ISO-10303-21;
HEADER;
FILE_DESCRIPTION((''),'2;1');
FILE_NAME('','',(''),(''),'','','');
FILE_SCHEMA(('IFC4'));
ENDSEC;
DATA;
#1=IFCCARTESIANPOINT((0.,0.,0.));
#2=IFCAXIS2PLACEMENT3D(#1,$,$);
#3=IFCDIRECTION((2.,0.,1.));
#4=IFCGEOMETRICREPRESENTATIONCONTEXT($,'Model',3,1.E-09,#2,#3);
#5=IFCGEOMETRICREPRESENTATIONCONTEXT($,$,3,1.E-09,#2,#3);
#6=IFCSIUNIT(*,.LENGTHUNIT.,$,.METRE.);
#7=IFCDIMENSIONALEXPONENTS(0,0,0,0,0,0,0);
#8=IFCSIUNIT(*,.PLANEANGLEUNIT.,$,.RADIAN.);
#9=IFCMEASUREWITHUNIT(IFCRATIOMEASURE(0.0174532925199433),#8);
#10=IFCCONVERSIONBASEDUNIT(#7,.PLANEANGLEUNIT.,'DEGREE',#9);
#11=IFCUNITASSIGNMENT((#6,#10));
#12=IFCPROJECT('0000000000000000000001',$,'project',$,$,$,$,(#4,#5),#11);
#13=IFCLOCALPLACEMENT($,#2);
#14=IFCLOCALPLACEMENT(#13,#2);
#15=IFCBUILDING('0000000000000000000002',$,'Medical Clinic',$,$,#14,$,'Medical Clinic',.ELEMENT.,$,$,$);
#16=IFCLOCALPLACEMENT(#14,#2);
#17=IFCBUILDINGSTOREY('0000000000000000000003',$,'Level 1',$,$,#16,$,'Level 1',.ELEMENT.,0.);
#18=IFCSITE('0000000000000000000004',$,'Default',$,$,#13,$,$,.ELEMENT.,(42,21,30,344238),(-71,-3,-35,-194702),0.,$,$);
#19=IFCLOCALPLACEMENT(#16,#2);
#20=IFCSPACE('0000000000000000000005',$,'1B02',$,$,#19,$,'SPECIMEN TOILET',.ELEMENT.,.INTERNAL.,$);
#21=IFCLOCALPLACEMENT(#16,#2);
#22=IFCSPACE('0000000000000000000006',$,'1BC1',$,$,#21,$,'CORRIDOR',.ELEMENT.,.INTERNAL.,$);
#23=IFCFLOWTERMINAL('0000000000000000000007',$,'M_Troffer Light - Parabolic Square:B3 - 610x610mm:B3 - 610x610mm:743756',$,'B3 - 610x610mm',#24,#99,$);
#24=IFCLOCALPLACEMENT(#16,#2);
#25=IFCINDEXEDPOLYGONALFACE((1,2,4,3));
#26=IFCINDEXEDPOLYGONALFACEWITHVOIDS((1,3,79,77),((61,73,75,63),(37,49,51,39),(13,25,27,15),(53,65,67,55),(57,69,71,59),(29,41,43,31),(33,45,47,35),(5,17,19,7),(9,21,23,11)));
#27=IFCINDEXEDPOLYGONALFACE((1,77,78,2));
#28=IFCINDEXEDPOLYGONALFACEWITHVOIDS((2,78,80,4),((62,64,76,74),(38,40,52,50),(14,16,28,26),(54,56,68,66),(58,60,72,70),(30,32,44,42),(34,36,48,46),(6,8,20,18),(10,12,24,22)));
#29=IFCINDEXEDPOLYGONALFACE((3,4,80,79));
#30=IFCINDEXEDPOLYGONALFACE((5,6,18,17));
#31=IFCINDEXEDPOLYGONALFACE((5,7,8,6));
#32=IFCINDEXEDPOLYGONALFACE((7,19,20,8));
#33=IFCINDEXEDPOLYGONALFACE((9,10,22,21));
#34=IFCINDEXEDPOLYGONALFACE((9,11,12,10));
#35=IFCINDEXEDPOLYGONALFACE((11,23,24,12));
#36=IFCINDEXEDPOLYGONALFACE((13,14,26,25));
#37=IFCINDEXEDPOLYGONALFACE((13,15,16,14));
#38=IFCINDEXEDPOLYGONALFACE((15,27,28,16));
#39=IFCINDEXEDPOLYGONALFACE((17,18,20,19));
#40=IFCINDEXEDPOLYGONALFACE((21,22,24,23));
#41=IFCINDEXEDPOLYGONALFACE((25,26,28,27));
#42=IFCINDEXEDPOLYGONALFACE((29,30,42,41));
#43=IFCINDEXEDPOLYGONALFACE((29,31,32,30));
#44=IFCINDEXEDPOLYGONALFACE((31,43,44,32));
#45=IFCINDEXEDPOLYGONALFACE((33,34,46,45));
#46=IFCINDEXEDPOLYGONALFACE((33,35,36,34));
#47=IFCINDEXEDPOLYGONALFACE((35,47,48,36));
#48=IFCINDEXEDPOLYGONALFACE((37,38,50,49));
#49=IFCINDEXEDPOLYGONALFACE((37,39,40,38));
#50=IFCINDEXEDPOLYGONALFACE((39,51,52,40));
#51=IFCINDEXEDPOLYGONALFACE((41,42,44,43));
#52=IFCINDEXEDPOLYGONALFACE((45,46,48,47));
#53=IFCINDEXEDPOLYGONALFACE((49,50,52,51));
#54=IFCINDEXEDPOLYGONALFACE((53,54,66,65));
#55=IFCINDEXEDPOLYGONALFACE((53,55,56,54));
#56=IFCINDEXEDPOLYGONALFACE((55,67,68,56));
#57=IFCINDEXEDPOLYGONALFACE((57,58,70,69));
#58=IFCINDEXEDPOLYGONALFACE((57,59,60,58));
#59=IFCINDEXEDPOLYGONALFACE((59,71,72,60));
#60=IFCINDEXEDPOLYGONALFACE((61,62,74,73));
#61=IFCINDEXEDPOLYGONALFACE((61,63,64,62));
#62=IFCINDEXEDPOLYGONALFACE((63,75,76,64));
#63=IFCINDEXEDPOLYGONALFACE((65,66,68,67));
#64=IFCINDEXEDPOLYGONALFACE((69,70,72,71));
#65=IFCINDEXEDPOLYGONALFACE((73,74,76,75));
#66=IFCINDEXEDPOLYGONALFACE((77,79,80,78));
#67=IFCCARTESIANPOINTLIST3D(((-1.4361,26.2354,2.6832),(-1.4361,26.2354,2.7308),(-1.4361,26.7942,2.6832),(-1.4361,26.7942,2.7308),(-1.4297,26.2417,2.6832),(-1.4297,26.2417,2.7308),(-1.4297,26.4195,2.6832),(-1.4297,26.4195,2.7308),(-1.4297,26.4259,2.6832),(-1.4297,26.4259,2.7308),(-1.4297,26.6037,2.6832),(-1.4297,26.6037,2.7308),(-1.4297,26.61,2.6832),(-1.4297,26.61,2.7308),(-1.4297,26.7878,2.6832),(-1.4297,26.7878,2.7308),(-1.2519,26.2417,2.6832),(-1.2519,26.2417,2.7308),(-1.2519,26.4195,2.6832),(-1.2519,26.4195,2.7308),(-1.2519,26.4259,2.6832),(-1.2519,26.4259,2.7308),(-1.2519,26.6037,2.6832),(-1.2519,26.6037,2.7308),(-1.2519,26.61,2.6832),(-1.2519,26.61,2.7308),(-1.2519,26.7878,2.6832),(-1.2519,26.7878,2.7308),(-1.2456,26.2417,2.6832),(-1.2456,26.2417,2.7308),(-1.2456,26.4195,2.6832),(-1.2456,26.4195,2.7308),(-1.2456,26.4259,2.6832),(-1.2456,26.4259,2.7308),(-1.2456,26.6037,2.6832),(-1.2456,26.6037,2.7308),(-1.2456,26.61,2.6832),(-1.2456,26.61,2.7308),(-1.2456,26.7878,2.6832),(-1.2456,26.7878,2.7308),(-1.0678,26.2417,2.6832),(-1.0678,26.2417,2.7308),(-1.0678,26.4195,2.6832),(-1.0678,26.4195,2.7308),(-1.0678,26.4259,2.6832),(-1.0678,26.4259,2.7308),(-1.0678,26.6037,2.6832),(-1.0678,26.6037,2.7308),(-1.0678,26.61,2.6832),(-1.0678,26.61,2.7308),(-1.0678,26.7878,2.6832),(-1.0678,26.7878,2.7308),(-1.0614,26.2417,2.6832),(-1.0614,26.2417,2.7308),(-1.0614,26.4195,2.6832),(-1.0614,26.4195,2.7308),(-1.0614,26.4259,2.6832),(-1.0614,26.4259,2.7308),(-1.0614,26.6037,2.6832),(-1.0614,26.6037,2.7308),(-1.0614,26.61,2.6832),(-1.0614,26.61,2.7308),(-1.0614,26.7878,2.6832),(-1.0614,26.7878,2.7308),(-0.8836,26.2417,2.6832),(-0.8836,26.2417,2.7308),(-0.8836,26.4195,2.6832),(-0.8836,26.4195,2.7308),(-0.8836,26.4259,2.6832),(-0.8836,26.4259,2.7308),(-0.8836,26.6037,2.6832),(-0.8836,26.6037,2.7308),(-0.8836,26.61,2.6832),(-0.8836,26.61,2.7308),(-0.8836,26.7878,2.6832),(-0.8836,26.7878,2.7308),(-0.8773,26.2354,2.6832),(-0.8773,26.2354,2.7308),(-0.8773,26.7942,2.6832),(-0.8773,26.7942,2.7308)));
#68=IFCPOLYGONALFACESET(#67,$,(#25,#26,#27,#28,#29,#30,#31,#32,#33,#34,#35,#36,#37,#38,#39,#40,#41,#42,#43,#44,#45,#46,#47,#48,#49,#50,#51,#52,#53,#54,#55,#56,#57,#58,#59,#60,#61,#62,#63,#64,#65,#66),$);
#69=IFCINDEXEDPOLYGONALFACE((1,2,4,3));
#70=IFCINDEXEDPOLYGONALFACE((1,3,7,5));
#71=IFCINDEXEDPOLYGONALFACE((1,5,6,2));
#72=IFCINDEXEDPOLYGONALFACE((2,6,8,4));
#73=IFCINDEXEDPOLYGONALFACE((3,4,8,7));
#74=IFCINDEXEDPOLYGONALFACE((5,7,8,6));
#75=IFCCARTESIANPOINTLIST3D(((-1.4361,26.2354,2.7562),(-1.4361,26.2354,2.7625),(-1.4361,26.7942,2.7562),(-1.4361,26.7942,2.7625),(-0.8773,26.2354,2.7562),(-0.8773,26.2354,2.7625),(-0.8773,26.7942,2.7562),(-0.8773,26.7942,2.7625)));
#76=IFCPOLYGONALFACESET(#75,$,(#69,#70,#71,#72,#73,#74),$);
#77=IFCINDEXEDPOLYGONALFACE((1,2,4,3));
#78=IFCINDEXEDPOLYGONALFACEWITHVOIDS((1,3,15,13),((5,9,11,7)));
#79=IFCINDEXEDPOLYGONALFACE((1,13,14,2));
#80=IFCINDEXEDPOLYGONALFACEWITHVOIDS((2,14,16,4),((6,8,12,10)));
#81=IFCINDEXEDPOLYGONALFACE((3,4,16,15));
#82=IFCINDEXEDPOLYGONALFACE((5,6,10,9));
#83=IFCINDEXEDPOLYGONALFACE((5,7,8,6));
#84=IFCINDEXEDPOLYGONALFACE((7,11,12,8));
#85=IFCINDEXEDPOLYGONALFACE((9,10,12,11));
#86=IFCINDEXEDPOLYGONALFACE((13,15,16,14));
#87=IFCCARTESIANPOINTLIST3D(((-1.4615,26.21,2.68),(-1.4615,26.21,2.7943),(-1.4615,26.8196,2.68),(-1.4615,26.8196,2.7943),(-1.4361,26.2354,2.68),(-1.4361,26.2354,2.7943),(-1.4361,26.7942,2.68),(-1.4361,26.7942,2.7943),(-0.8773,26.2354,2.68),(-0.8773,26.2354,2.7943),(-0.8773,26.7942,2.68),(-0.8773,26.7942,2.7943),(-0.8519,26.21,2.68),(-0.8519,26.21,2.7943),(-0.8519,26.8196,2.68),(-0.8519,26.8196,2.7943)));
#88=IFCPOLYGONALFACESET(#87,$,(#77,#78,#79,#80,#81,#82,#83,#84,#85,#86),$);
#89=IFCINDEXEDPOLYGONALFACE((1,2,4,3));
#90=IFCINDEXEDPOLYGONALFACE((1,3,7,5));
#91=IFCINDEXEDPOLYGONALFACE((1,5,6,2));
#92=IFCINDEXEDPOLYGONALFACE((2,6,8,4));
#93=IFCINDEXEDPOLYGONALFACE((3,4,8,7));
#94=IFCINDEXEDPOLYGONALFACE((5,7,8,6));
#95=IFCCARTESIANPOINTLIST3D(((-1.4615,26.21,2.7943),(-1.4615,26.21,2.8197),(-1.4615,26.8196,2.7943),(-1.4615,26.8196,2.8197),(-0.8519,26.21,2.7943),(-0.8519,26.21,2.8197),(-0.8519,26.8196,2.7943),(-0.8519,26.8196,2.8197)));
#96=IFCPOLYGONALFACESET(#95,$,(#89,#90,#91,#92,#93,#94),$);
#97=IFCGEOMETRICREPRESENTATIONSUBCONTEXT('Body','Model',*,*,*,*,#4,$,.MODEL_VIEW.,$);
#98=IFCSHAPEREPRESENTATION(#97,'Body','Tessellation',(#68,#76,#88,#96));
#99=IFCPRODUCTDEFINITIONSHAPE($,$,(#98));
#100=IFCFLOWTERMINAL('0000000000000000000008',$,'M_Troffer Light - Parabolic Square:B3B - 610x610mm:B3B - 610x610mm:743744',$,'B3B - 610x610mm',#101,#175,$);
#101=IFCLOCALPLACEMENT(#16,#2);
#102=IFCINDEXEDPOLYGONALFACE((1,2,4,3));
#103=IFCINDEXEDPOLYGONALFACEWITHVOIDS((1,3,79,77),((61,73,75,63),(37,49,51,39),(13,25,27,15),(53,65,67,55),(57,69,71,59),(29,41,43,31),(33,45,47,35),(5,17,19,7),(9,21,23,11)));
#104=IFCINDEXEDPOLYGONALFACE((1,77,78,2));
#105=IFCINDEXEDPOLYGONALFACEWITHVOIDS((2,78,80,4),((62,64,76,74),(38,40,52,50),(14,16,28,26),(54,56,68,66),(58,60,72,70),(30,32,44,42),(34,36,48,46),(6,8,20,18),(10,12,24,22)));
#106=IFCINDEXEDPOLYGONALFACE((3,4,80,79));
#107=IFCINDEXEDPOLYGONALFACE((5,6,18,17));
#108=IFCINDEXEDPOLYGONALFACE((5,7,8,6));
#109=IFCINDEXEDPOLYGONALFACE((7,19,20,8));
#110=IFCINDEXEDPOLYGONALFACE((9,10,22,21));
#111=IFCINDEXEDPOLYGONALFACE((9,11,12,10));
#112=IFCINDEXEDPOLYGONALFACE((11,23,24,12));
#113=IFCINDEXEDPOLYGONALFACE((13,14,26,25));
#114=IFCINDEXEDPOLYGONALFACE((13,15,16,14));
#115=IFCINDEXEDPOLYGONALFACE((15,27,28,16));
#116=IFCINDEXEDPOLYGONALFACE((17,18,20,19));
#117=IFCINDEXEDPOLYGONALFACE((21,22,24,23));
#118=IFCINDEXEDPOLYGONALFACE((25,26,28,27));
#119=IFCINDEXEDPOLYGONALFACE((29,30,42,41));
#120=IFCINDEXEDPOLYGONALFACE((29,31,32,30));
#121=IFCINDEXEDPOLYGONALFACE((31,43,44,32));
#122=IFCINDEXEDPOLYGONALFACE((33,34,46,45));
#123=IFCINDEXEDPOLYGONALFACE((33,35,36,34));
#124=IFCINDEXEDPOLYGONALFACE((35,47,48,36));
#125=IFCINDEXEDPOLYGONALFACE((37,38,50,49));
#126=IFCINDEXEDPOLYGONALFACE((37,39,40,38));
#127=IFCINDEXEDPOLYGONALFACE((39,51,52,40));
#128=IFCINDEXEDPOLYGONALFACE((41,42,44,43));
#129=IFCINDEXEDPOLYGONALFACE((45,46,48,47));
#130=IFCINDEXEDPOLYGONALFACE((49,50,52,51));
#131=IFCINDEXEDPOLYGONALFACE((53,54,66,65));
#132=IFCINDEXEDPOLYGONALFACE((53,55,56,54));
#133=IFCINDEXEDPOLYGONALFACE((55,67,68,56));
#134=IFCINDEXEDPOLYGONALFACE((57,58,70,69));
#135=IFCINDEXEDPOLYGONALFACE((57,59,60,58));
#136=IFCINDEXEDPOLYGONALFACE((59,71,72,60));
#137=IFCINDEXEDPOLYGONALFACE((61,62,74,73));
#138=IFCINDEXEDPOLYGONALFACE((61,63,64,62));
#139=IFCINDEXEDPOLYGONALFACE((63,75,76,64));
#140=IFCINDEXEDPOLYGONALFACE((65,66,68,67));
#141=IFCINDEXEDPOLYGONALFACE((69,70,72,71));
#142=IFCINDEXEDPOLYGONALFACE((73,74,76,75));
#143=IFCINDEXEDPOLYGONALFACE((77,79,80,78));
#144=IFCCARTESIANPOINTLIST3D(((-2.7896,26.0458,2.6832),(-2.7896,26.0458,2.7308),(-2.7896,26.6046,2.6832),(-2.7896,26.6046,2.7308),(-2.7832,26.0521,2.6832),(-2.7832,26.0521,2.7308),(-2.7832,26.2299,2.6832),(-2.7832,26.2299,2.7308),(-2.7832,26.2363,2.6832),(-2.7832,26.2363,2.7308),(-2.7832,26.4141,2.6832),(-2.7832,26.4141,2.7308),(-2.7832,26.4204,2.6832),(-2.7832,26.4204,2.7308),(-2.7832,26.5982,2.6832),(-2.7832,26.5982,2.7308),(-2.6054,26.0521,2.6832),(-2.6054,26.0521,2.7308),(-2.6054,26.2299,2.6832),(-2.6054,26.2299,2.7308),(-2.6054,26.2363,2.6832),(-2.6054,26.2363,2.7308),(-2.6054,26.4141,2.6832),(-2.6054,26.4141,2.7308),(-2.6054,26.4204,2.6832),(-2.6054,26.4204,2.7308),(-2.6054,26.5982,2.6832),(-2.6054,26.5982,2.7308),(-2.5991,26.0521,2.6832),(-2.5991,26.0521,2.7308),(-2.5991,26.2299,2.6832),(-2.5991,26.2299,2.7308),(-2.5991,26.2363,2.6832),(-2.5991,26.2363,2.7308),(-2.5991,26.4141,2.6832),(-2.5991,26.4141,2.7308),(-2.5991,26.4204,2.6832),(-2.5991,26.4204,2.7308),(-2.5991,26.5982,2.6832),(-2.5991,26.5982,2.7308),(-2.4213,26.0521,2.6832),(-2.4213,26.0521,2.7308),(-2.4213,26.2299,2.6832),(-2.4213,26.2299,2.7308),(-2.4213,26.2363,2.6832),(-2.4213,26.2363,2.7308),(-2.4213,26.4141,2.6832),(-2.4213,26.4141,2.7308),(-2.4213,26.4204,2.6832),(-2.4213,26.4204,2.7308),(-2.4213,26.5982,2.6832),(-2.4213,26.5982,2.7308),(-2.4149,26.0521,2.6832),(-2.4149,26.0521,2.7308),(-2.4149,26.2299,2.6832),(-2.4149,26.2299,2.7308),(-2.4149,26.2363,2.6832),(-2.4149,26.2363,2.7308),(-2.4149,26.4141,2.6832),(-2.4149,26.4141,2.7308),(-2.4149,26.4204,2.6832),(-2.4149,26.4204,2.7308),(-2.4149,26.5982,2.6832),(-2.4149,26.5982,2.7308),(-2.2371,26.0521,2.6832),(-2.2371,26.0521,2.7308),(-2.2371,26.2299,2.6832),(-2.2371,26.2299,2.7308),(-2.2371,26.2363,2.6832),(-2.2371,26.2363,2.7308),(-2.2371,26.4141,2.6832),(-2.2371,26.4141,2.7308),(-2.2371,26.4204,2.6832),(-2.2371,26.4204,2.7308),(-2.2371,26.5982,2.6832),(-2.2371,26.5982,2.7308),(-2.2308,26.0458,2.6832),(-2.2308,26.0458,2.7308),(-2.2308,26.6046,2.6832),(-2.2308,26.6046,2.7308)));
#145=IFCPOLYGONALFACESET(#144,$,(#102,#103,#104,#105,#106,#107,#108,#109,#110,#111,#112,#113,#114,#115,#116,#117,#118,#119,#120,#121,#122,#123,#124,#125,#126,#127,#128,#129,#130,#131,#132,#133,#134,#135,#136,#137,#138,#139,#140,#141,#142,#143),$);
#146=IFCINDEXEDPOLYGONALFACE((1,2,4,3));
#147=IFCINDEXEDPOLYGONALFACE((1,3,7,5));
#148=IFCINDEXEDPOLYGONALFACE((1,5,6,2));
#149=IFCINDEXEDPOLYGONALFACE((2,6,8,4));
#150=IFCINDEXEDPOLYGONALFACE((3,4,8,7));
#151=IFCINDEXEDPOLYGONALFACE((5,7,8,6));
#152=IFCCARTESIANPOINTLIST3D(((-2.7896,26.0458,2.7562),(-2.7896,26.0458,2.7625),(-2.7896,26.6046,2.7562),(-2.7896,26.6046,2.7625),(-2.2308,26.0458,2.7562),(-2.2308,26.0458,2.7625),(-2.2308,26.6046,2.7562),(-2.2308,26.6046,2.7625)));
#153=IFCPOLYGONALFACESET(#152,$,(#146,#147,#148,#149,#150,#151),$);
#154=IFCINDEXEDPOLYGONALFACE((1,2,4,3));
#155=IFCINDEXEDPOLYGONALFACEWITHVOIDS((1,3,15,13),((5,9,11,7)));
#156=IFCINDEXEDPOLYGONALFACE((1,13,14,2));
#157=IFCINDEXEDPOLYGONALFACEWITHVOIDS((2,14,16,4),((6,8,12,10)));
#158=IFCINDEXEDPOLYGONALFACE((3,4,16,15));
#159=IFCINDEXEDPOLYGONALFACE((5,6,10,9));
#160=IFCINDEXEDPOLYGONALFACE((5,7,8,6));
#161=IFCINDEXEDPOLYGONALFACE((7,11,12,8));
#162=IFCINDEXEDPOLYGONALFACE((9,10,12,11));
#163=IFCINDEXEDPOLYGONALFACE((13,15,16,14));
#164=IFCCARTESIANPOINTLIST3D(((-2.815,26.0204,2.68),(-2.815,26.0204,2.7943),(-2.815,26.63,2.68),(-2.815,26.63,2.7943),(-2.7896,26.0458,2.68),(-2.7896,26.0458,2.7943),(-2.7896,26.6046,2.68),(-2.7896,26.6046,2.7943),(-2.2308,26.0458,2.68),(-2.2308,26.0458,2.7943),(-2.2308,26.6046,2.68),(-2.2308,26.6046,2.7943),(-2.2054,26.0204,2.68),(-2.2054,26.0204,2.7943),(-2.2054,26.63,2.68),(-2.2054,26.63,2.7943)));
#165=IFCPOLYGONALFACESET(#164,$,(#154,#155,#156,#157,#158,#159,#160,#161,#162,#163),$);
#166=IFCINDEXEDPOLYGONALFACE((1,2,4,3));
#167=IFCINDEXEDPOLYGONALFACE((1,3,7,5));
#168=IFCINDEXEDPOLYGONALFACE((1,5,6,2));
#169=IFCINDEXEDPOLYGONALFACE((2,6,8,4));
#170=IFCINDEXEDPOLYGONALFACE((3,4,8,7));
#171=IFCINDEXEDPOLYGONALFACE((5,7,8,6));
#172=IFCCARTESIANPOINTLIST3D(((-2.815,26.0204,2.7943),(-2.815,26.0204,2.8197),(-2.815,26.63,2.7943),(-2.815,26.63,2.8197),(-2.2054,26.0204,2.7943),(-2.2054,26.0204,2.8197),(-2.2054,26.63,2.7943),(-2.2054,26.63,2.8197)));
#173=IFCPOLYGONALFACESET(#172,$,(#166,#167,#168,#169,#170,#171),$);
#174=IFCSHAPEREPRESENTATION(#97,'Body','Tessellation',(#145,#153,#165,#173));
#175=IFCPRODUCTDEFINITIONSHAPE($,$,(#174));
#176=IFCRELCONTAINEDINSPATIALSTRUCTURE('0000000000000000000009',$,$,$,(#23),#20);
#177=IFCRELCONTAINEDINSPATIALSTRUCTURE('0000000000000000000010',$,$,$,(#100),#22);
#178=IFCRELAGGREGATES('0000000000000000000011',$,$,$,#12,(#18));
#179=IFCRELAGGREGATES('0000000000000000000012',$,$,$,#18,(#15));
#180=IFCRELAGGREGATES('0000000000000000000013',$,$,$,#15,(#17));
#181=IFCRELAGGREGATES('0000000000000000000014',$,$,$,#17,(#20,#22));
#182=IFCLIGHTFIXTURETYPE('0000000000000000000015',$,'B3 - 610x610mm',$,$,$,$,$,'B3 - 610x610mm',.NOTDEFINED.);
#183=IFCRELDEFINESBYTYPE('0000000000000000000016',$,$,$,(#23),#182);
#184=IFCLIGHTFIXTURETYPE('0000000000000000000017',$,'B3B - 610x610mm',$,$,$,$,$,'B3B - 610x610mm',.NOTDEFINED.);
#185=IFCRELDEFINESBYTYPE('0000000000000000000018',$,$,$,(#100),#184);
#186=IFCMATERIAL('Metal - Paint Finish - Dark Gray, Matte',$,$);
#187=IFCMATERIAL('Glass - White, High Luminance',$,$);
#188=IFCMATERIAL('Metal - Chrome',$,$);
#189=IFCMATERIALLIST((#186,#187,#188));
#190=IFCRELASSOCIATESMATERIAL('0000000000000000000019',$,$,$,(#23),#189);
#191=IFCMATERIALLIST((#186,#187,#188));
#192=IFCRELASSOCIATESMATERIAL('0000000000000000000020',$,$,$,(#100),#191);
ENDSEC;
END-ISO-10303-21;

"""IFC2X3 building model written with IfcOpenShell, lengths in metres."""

from ifc_helpers import new_model, entity, si_unit, converted_unit, direction, frame, origin, origin_2d_with_axis, place, context, subcontext, project, spatial, polyline, rectangle, outline, extrude, source, transform, mapped, material, material_list, type_object, type_shapes, element, save


model = new_model("IFC2X3")

# Units and contexts
model_context = context("Model", 3, precision=1e-09, world=origin(), true_north=direction((2.0, 0.0, 1.0)))
context_of_model = context(None, 3, precision=1e-09, world=origin(), true_north=direction((2.0, 0.0, 1.0)))
body_context = subcontext(model_context, "Body", "Model", "MODEL_VIEW")
ifc_project = project(units=[si_unit("LENGTHUNIT", "METRE"), converted_unit("PLANEANGLEUNIT", "DEGREE", entity("IfcRatioMeasure", 0.0174532925199433), si_unit("PLANEANGLEUNIT", "RADIAN"), dimensions=[0, 0, 0, 0, 0, 0, 0])], contexts=[model_context, context_of_model])

# Site, building, storey, space
site_placement = place(None, origin())
site = spatial("IfcSite", under=ifc_project, at=site_placement, Name="Default", CompositionType="ELEMENT", RefLatitude=(42, 21, 30, 344238), RefLongitude=(-71, -3, -35, -194702), RefElevation=0.0)
building_placement = place(site_placement, origin())
building = spatial("IfcBuilding", under=site, at=building_placement, Name="Medical Clinic", LongName="Medical Clinic", CompositionType="ELEMENT")
storey_placement = place(building_placement, origin())
storey = spatial("IfcBuildingStorey", under=building, at=storey_placement, Name="Level 1", LongName="Level 1", CompositionType="ELEMENT", Elevation=0.0)
space_1_placement = place(storey_placement, origin())
space_1 = spatial("IfcSpace", under=storey, at=space_1_placement, Name="1B02", LongName="SPECIMEN TOILET", CompositionType="ELEMENT", InteriorOrExteriorSpace="INTERNAL")

# Flow terminal
ifc_material_1 = material(Name="Metal - Paint Finish - Dark Gray, Matte")
ifc_material_2 = material(Name="Glass - White, High Luminance")
ifc_material_3 = material(Name="Metal - Chrome")
ifc_material_list_1 = material_list([ifc_material_1, ifc_material_2, ifc_material_3])
light_fixture_type_1 = type_object("IfcLightFixtureType", Name="B3 - 610x610mm", ElementType="B3 - 610x610mm", PredefinedType="NOTDEFINED")
shared_shape_1 = source(origin(), body_context, "Body", "SweptSolid", [
    extrude(outline(polyline([(-0.2794, -0.2794), (0.2794, -0.2794), (0.2794, 0.2794), (-0.2794, 0.2794), (-0.2794, -0.2794)]), holes=[polyline([(-0.0952, 0.0953), (-0.273, 0.0953), (-0.273, 0.2731), (-0.0952, 0.2731), (-0.0952, 0.0953)]), polyline([(0.2731, 0.0953), (0.0953, 0.0953), (0.0953, 0.2731), (0.2731, 0.2731), (0.2731, 0.0953)]), polyline([(-0.0889, 0.2731), (0.0889, 0.2731), (0.0889, 0.0953), (-0.0889, 0.0953), (-0.0889, 0.2731)]), polyline([(0.2731, -0.273), (0.0953, -0.273), (0.0953, -0.0952), (0.2731, -0.0952), (0.2731, -0.273)]), polyline([(0.0889, -0.273), (-0.0889, -0.273), (-0.0889, -0.0952), (0.0889, -0.0952), (0.0889, -0.273)]), polyline([(-0.0952, -0.273), (-0.273, -0.273), (-0.273, -0.0952), (-0.0952, -0.0952), (-0.0952, -0.273)]), polyline([(-0.0952, -0.0889), (-0.273, -0.0889), (-0.273, 0.0889), (-0.0952, 0.0889), (-0.0952, -0.0889)]), polyline([(0.0889, -0.0889), (-0.0889, -0.0889), (-0.0889, 0.0889), (0.0889, 0.0889), (0.0889, -0.0889)]), polyline([(0.2731, -0.0889), (0.0953, -0.0889), (0.0953, 0.0889), (0.2731, 0.0889), (0.2731, -0.0889)])]), frame((0.0, -0.3048, -0.0508), z_axis=(0.0, 0.0, 1.0), x_axis=(-1.0, 0.0, 0.0)), (0.0, 0.0, 1.0), 0.0476),
    extrude(rectangle(XDim=0.5588, YDim=0.5588, at=origin_2d_with_axis()), frame((0.0, -0.3048, -0.0825), z_axis=(0.0, 0.0, 1.0), x_axis=(-1.0, 0.0, 0.0)), (0.0, 0.0, 1.0), 0.0064),
    extrude(outline(polyline([(-0.3048, -0.3048), (0.3048, -0.3048), (0.3048, 0.3048), (-0.3048, 0.3048), (-0.3048, -0.3048)]), holes=[polyline([(0.2794, 0.2794), (0.2794, -0.2794), (-0.2794, -0.2794), (-0.2794, 0.2794), (0.2794, 0.2794)])]), frame((0.0, -0.3048, -0.1143)), (0.0, 0.0, 1.0), 0.1143),
    extrude(rectangle(XDim=0.6096, YDim=0.6096, at=origin_2d_with_axis()), frame((0.0, -0.3048, -0.1397), z_axis=(0.0, 0.0, 1.0), x_axis=(-1.0, 0.0, 0.0)), (0.0, 0.0, 1.0), 0.0254),
])
type_shapes(light_fixture_type_1, [shared_shape_1])
flow_terminal_1_placement = place(space_1_placement, frame((-1.1567, 26.21, 2.68), z_axis=(0.0, 0.0, -1.0), x_axis=(1.0, 0.0, 0.0)))
element("IfcFlowTerminal", 1, at=flow_terminal_1_placement, inside=space_1, type_object=light_fixture_type_1, material=ifc_material_list_1, Name="M_Troffer Light - Parabolic Square:B3 - 610x610mm:B3 - 610x610mm:743756", ObjectType="B3 - 610x610mm", context=body_context, shape_type="MappedRepresentation", body=[
    mapped(shared_shape_1, transform((0.0, 0.0, 0.0), scale=1.0)),
])

# Shared definitions
space_2_placement = place(storey_placement, origin())
space_2 = spatial("IfcSpace", under=storey, at=space_2_placement, Name="1BC1", LongName="CORRIDOR", CompositionType="ELEMENT", InteriorOrExteriorSpace="INTERNAL")

# Flow terminal
ifc_material_list_2 = material_list([ifc_material_1, ifc_material_2, ifc_material_3])
light_fixture_type_2 = type_object("IfcLightFixtureType", Name="B3B - 610x610mm", ElementType="B3B - 610x610mm", PredefinedType="NOTDEFINED")
shared_shape_2 = source(origin(), body_context, "Body", "SweptSolid", [
    extrude(outline(polyline([(-0.2794, -0.2794), (0.2794, -0.2794), (0.2794, 0.2794), (-0.2794, 0.2794), (-0.2794, -0.2794)]), holes=[polyline([(-0.0952, 0.0953), (-0.273, 0.0953), (-0.273, 0.2731), (-0.0952, 0.2731), (-0.0952, 0.0953)]), polyline([(0.2731, 0.0953), (0.0953, 0.0953), (0.0953, 0.2731), (0.2731, 0.2731), (0.2731, 0.0953)]), polyline([(-0.0889, 0.2731), (0.0889, 0.2731), (0.0889, 0.0953), (-0.0889, 0.0953), (-0.0889, 0.2731)]), polyline([(0.2731, -0.273), (0.0953, -0.273), (0.0953, -0.0952), (0.2731, -0.0952), (0.2731, -0.273)]), polyline([(0.0889, -0.273), (-0.0889, -0.273), (-0.0889, -0.0952), (0.0889, -0.0952), (0.0889, -0.273)]), polyline([(-0.0952, -0.273), (-0.273, -0.273), (-0.273, -0.0952), (-0.0952, -0.0952), (-0.0952, -0.273)]), polyline([(-0.0952, -0.0889), (-0.273, -0.0889), (-0.273, 0.0889), (-0.0952, 0.0889), (-0.0952, -0.0889)]), polyline([(0.0889, -0.0889), (-0.0889, -0.0889), (-0.0889, 0.0889), (0.0889, 0.0889), (0.0889, -0.0889)]), polyline([(0.2731, -0.0889), (0.0953, -0.0889), (0.0953, 0.0889), (0.2731, 0.0889), (0.2731, -0.0889)])]), frame((0.0, -0.3048, -0.0508), z_axis=(0.0, 0.0, 1.0), x_axis=(-1.0, 0.0, 0.0)), (0.0, 0.0, 1.0), 0.0476),
    extrude(rectangle(XDim=0.5588, YDim=0.5588, at=origin_2d_with_axis()), frame((0.0, -0.3048, -0.0825), z_axis=(0.0, 0.0, 1.0), x_axis=(-1.0, 0.0, 0.0)), (0.0, 0.0, 1.0), 0.0064),
    extrude(outline(polyline([(-0.3048, -0.3048), (0.3048, -0.3048), (0.3048, 0.3048), (-0.3048, 0.3048), (-0.3048, -0.3048)]), holes=[polyline([(0.2794, 0.2794), (0.2794, -0.2794), (-0.2794, -0.2794), (-0.2794, 0.2794), (0.2794, 0.2794)])]), frame((0.0, -0.3048, -0.1143)), (0.0, 0.0, 1.0), 0.1143),
    extrude(rectangle(XDim=0.6096, YDim=0.6096, at=origin_2d_with_axis()), frame((0.0, -0.3048, -0.1397), z_axis=(0.0, 0.0, 1.0), x_axis=(-1.0, 0.0, 0.0)), (0.0, 0.0, 1.0), 0.0254),
])
type_shapes(light_fixture_type_2, [shared_shape_2])
flow_terminal_2_placement = place(space_2_placement, frame((-2.5102, 26.0204, 2.68), z_axis=(0.0, 0.0, -1.0), x_axis=(1.0, 0.0, 0.0)))
element("IfcFlowTerminal", 2, at=flow_terminal_2_placement, inside=space_2, type_object=light_fixture_type_2, material=ifc_material_list_2, Name="M_Troffer Light - Parabolic Square:B3B - 610x610mm:B3B - 610x610mm:743744", ObjectType="B3B - 610x610mm", context=body_context, shape_type="MappedRepresentation", body=[
    mapped(shared_shape_2, transform((0.0, 0.0, 0.0), scale=1.0)),
])

save(model, "model.ifc")
